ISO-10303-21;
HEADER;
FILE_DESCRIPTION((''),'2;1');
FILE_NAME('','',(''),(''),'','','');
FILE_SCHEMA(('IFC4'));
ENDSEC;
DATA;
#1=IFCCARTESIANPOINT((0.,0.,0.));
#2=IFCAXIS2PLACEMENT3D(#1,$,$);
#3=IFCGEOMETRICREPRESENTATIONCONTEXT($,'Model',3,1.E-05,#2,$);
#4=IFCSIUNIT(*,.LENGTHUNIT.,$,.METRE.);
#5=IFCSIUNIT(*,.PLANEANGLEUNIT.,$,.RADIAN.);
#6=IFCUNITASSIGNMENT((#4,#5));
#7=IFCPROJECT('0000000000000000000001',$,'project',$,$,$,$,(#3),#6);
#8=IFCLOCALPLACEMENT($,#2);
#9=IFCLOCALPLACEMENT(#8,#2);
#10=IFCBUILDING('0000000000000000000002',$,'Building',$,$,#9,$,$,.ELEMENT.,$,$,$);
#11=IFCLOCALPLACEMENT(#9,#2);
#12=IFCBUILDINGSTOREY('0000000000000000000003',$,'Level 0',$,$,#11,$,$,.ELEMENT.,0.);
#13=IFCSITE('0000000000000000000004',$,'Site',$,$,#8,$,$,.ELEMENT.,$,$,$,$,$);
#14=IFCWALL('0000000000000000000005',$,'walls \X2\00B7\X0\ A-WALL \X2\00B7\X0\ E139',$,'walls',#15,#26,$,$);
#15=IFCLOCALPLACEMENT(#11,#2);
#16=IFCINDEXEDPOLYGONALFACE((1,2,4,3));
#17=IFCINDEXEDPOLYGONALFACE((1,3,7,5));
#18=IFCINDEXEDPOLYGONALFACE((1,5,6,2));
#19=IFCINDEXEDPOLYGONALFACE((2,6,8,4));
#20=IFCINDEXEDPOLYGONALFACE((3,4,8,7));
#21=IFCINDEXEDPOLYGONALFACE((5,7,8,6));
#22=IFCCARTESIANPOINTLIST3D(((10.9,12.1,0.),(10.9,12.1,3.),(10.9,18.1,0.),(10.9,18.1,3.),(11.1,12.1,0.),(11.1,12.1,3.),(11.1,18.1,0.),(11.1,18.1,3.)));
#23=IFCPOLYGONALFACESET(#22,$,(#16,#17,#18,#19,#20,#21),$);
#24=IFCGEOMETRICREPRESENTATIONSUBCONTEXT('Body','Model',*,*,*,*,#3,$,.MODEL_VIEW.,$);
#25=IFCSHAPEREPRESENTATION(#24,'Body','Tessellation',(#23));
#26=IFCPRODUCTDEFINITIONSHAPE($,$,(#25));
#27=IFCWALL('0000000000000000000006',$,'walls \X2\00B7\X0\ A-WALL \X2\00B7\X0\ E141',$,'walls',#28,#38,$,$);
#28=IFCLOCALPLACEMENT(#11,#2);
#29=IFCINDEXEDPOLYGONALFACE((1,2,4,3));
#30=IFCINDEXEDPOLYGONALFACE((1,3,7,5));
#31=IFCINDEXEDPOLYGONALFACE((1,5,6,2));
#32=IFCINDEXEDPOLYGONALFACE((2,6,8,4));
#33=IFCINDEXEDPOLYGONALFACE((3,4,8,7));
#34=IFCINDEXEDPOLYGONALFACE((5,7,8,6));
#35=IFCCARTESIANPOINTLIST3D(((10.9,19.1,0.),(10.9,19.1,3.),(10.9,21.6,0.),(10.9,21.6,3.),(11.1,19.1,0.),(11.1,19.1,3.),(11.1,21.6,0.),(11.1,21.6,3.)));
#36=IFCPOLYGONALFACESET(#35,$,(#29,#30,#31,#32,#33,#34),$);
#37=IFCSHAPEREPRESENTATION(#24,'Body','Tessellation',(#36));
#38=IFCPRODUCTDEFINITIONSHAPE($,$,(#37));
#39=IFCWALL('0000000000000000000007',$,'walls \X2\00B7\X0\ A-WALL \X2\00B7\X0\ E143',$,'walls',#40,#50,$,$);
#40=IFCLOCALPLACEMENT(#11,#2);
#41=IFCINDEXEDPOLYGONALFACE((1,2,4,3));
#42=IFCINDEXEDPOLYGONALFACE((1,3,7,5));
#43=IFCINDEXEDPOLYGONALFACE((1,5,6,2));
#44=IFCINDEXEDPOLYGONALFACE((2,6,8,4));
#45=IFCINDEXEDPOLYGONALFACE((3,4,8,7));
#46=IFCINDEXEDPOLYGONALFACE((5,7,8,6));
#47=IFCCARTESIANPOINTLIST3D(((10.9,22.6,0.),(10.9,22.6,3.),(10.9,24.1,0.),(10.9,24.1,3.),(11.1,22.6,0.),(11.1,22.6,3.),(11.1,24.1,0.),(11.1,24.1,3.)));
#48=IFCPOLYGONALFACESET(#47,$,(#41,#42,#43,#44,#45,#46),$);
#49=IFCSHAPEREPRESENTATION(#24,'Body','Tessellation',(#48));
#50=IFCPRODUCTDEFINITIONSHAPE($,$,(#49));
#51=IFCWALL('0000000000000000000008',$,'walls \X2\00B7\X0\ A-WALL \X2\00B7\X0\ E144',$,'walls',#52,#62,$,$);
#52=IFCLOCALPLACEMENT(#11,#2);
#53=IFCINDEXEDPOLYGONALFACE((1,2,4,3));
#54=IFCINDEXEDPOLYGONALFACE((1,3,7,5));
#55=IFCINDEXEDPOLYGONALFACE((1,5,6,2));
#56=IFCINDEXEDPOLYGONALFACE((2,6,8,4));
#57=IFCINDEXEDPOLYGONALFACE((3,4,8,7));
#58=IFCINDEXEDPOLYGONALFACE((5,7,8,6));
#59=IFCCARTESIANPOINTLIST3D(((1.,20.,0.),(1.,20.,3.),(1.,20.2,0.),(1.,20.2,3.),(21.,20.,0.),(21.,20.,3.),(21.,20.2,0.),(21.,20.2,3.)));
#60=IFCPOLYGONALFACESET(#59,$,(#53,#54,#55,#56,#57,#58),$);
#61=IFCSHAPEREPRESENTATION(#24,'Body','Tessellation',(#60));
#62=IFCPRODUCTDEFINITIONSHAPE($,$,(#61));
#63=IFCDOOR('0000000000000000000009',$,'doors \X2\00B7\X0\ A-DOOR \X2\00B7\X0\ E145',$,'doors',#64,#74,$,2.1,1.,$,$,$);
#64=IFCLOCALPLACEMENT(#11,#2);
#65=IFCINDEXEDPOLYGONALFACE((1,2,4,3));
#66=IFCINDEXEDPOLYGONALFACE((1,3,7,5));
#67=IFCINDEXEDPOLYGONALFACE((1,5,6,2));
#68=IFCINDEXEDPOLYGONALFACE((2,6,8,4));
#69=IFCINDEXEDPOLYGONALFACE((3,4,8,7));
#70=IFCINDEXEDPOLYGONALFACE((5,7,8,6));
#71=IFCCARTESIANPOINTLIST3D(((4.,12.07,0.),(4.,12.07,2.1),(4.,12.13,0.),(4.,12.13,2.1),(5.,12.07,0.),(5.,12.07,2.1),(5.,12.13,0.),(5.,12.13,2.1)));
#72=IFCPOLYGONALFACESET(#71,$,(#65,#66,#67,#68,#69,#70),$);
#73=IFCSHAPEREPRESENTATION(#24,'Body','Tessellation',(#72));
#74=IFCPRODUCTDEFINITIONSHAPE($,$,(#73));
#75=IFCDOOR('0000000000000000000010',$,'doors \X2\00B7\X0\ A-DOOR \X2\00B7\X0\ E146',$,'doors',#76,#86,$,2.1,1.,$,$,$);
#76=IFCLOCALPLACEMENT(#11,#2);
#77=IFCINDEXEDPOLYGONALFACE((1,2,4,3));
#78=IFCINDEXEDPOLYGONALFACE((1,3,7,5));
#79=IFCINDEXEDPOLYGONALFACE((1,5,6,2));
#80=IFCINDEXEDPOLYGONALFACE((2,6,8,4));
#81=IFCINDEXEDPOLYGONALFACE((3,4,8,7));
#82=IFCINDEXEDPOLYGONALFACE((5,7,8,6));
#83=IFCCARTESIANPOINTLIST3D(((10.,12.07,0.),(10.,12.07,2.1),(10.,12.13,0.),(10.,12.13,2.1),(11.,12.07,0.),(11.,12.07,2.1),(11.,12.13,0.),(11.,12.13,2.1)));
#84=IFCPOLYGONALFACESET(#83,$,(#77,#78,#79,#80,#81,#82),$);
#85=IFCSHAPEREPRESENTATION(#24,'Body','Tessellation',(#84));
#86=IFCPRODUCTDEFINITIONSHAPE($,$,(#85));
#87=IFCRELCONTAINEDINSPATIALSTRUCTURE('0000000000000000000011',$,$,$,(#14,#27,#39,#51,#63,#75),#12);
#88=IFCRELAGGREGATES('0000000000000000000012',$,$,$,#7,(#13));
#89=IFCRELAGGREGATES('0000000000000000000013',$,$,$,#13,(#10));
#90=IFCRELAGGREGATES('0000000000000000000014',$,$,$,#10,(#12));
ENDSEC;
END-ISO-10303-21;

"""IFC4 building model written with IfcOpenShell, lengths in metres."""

from ifc_helpers import new_model, si_unit, origin, place, context, subcontext, project, spatial, polyline, outline, extrude, element, save


model = new_model("IFC4")

# Units and contexts
model_context = context("Model", 3, precision=1e-05, world=origin())
body_context = subcontext(model_context, "Body", "Model", "MODEL_VIEW")
ifc_project = project(units=[si_unit("LENGTHUNIT", "METRE"), si_unit("PLANEANGLEUNIT", "RADIAN")], contexts=[model_context])

# Site, building, storey
site_placement = place(None, origin())
site = spatial("IfcSite", under=ifc_project, at=site_placement, Name="Site", CompositionType="ELEMENT")
building_placement = place(site_placement, origin())
building = spatial("IfcBuilding", under=site, at=building_placement, Name="Building", CompositionType="ELEMENT")
storey_placement = place(building_placement, origin())
storey = spatial("IfcBuildingStorey", under=building, at=storey_placement, Name="Level 0", CompositionType="ELEMENT", Elevation=0.0)

# Walls
wall_1_placement = place(storey_placement, origin())
element("IfcWall", 1, at=wall_1_placement, inside=storey, Name="walls · A-WALL · E139", ObjectType="walls", context=body_context, shape_type="SweptSolid", body=[
    extrude(outline(polyline([(11.1, 12.1), (11.1, 18.1), (10.9, 18.1), (10.9, 12.1), (11.1, 12.1)])), origin(), (0.0, 0.0, 1.0), 3.0),
])
wall_2_placement = place(storey_placement, origin())
element("IfcWall", 2, at=wall_2_placement, inside=storey, Name="walls · A-WALL · E141", ObjectType="walls", context=body_context, shape_type="SweptSolid", body=[
    extrude(outline(polyline([(11.1, 19.1), (11.1, 21.6), (10.9, 21.6), (10.9, 19.1), (11.1, 19.1)])), origin(), (0.0, 0.0, 1.0), 3.0),
])
wall_3_placement = place(storey_placement, origin())
element("IfcWall", 3, at=wall_3_placement, inside=storey, Name="walls · A-WALL · E143", ObjectType="walls", context=body_context, shape_type="SweptSolid", body=[
    extrude(outline(polyline([(11.1, 22.6), (11.1, 24.1), (10.9, 24.1), (10.9, 22.6), (11.1, 22.6)])), origin(), (0.0, 0.0, 1.0), 3.0),
])
wall_4_placement = place(storey_placement, origin())
element("IfcWall", 4, at=wall_4_placement, inside=storey, Name="walls · A-WALL · E144", ObjectType="walls", context=body_context, shape_type="SweptSolid", body=[
    extrude(outline(polyline([(1.0, 20.0), (21.0, 20.0), (21.0, 20.2), (1.0, 20.2), (1.0, 20.0)])), origin(), (0.0, 0.0, 1.0), 3.0),
])

# Doors
door_1_placement = place(storey_placement, origin())
element("IfcDoor", 5, at=door_1_placement, inside=storey, Name="doors · A-DOOR · E145", ObjectType="doors", OverallHeight=2.1, OverallWidth=1.0, context=body_context, shape_type="SweptSolid", body=[
    extrude(outline(polyline([(4.0, 12.07), (5.0, 12.07), (5.0, 12.13), (4.0, 12.13), (4.0, 12.07)])), origin(), (0.0, 0.0, 1.0), 2.1),
])
door_2_placement = place(storey_placement, origin())
element("IfcDoor", 6, at=door_2_placement, inside=storey, Name="doors · A-DOOR · E146", ObjectType="doors", OverallHeight=2.1, OverallWidth=1.0, context=body_context, shape_type="SweptSolid", body=[
    extrude(outline(polyline([(10.0, 12.07), (11.0, 12.07), (11.0, 12.13), (10.0, 12.13), (10.0, 12.07)])), origin(), (0.0, 0.0, 1.0), 2.1),
])

save(model, "model.ifc")
